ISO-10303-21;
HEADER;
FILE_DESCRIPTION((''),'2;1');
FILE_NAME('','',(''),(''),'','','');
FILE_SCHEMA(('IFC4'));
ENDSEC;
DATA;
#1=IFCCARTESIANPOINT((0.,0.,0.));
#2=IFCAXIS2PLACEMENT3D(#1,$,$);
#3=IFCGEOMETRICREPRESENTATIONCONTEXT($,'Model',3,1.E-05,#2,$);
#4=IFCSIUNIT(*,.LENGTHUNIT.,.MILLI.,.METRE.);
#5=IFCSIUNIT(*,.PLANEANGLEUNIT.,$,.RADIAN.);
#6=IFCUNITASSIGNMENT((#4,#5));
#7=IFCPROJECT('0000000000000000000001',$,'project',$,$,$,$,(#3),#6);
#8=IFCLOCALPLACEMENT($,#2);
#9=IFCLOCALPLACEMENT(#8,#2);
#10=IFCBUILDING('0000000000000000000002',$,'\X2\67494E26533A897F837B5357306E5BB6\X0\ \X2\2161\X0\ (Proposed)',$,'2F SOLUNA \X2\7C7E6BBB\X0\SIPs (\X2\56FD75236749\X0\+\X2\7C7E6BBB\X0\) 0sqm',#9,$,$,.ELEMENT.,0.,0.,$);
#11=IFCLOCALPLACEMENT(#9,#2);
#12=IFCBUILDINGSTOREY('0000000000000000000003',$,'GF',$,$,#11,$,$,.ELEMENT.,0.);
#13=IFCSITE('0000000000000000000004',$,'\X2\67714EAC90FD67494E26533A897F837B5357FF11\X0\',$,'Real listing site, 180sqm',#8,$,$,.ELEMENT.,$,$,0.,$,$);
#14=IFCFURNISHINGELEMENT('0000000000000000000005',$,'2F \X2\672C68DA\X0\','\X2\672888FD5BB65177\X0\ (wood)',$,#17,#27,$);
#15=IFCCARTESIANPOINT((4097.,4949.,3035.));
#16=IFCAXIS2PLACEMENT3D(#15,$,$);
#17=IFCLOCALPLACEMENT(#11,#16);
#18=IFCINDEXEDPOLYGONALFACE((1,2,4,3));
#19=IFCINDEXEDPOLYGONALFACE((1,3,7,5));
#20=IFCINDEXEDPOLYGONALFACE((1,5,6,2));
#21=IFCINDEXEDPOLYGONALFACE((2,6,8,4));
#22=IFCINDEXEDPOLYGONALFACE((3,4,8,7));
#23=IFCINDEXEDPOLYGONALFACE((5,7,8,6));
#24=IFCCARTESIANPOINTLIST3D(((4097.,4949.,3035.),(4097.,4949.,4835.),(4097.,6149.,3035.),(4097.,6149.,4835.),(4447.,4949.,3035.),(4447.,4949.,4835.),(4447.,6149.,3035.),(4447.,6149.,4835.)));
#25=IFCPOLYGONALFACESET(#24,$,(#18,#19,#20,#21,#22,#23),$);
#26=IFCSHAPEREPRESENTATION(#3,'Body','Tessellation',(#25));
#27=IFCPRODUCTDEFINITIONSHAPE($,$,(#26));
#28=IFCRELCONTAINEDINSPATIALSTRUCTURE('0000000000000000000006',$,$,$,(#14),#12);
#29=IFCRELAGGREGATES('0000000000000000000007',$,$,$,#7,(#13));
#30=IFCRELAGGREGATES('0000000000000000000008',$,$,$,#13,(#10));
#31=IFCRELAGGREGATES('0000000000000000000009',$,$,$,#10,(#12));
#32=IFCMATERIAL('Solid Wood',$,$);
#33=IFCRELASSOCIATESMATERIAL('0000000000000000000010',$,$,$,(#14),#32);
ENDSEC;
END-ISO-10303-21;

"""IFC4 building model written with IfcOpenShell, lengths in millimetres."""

from ifc_helpers import new_model, si_unit, frame, frame_2d, origin, place, context, project, spatial, rectangle, extrude, material, element, save


model = new_model("IFC4")

# Units and contexts
model_context = context("Model", 3, precision=1e-05, world=origin())
ifc_project = project(units=[si_unit("LENGTHUNIT", "METRE", prefix="MILLI"), si_unit("PLANEANGLEUNIT", "RADIAN")], contexts=[model_context])

# Site, building, storey
site_placement = place(None, origin())
site = spatial("IfcSite", under=ifc_project, at=site_placement, Name="東京都杉並区西荻南１", ObjectType="Real listing site, 180sqm", CompositionType="ELEMENT", RefElevation=0.0)
building_placement = place(site_placement, origin())
building = spatial("IfcBuilding", under=site, at=building_placement, Name="杉並区西荻南の家 Ⅱ (Proposed)", ObjectType="2F SOLUNA 籾殻SIPs (国産杉+籾殻) 0sqm", CompositionType="ELEMENT", ElevationOfRefHeight=0.0, ElevationOfTerrain=0.0)
storey_placement = place(building_placement, origin())
storey = spatial("IfcBuildingStorey", under=building, at=storey_placement, Name="GF", CompositionType="ELEMENT", Elevation=0.0)

# Shared definitions
ifc_material_1 = material(Name="Solid Wood")

# Furnishing element
furnishing_1_placement = place(storey_placement, frame((4097.0, 4949.0, 3035.0)))
element("IfcFurnishingElement", 1, at=furnishing_1_placement, inside=storey, material=ifc_material_1, Name="2F 本棚", Description="木製家具 (wood)", context=model_context, shape_type="SweptSolid", body=[
    extrude(rectangle(XDim=350.0, YDim=1200.0, at=frame_2d((175.0, 600.0))), frame((4097.0, 4949.0, 3035.0)), (0.0, 0.0, 1.0), 1800.0),
])

save(model, "model.ifc")
